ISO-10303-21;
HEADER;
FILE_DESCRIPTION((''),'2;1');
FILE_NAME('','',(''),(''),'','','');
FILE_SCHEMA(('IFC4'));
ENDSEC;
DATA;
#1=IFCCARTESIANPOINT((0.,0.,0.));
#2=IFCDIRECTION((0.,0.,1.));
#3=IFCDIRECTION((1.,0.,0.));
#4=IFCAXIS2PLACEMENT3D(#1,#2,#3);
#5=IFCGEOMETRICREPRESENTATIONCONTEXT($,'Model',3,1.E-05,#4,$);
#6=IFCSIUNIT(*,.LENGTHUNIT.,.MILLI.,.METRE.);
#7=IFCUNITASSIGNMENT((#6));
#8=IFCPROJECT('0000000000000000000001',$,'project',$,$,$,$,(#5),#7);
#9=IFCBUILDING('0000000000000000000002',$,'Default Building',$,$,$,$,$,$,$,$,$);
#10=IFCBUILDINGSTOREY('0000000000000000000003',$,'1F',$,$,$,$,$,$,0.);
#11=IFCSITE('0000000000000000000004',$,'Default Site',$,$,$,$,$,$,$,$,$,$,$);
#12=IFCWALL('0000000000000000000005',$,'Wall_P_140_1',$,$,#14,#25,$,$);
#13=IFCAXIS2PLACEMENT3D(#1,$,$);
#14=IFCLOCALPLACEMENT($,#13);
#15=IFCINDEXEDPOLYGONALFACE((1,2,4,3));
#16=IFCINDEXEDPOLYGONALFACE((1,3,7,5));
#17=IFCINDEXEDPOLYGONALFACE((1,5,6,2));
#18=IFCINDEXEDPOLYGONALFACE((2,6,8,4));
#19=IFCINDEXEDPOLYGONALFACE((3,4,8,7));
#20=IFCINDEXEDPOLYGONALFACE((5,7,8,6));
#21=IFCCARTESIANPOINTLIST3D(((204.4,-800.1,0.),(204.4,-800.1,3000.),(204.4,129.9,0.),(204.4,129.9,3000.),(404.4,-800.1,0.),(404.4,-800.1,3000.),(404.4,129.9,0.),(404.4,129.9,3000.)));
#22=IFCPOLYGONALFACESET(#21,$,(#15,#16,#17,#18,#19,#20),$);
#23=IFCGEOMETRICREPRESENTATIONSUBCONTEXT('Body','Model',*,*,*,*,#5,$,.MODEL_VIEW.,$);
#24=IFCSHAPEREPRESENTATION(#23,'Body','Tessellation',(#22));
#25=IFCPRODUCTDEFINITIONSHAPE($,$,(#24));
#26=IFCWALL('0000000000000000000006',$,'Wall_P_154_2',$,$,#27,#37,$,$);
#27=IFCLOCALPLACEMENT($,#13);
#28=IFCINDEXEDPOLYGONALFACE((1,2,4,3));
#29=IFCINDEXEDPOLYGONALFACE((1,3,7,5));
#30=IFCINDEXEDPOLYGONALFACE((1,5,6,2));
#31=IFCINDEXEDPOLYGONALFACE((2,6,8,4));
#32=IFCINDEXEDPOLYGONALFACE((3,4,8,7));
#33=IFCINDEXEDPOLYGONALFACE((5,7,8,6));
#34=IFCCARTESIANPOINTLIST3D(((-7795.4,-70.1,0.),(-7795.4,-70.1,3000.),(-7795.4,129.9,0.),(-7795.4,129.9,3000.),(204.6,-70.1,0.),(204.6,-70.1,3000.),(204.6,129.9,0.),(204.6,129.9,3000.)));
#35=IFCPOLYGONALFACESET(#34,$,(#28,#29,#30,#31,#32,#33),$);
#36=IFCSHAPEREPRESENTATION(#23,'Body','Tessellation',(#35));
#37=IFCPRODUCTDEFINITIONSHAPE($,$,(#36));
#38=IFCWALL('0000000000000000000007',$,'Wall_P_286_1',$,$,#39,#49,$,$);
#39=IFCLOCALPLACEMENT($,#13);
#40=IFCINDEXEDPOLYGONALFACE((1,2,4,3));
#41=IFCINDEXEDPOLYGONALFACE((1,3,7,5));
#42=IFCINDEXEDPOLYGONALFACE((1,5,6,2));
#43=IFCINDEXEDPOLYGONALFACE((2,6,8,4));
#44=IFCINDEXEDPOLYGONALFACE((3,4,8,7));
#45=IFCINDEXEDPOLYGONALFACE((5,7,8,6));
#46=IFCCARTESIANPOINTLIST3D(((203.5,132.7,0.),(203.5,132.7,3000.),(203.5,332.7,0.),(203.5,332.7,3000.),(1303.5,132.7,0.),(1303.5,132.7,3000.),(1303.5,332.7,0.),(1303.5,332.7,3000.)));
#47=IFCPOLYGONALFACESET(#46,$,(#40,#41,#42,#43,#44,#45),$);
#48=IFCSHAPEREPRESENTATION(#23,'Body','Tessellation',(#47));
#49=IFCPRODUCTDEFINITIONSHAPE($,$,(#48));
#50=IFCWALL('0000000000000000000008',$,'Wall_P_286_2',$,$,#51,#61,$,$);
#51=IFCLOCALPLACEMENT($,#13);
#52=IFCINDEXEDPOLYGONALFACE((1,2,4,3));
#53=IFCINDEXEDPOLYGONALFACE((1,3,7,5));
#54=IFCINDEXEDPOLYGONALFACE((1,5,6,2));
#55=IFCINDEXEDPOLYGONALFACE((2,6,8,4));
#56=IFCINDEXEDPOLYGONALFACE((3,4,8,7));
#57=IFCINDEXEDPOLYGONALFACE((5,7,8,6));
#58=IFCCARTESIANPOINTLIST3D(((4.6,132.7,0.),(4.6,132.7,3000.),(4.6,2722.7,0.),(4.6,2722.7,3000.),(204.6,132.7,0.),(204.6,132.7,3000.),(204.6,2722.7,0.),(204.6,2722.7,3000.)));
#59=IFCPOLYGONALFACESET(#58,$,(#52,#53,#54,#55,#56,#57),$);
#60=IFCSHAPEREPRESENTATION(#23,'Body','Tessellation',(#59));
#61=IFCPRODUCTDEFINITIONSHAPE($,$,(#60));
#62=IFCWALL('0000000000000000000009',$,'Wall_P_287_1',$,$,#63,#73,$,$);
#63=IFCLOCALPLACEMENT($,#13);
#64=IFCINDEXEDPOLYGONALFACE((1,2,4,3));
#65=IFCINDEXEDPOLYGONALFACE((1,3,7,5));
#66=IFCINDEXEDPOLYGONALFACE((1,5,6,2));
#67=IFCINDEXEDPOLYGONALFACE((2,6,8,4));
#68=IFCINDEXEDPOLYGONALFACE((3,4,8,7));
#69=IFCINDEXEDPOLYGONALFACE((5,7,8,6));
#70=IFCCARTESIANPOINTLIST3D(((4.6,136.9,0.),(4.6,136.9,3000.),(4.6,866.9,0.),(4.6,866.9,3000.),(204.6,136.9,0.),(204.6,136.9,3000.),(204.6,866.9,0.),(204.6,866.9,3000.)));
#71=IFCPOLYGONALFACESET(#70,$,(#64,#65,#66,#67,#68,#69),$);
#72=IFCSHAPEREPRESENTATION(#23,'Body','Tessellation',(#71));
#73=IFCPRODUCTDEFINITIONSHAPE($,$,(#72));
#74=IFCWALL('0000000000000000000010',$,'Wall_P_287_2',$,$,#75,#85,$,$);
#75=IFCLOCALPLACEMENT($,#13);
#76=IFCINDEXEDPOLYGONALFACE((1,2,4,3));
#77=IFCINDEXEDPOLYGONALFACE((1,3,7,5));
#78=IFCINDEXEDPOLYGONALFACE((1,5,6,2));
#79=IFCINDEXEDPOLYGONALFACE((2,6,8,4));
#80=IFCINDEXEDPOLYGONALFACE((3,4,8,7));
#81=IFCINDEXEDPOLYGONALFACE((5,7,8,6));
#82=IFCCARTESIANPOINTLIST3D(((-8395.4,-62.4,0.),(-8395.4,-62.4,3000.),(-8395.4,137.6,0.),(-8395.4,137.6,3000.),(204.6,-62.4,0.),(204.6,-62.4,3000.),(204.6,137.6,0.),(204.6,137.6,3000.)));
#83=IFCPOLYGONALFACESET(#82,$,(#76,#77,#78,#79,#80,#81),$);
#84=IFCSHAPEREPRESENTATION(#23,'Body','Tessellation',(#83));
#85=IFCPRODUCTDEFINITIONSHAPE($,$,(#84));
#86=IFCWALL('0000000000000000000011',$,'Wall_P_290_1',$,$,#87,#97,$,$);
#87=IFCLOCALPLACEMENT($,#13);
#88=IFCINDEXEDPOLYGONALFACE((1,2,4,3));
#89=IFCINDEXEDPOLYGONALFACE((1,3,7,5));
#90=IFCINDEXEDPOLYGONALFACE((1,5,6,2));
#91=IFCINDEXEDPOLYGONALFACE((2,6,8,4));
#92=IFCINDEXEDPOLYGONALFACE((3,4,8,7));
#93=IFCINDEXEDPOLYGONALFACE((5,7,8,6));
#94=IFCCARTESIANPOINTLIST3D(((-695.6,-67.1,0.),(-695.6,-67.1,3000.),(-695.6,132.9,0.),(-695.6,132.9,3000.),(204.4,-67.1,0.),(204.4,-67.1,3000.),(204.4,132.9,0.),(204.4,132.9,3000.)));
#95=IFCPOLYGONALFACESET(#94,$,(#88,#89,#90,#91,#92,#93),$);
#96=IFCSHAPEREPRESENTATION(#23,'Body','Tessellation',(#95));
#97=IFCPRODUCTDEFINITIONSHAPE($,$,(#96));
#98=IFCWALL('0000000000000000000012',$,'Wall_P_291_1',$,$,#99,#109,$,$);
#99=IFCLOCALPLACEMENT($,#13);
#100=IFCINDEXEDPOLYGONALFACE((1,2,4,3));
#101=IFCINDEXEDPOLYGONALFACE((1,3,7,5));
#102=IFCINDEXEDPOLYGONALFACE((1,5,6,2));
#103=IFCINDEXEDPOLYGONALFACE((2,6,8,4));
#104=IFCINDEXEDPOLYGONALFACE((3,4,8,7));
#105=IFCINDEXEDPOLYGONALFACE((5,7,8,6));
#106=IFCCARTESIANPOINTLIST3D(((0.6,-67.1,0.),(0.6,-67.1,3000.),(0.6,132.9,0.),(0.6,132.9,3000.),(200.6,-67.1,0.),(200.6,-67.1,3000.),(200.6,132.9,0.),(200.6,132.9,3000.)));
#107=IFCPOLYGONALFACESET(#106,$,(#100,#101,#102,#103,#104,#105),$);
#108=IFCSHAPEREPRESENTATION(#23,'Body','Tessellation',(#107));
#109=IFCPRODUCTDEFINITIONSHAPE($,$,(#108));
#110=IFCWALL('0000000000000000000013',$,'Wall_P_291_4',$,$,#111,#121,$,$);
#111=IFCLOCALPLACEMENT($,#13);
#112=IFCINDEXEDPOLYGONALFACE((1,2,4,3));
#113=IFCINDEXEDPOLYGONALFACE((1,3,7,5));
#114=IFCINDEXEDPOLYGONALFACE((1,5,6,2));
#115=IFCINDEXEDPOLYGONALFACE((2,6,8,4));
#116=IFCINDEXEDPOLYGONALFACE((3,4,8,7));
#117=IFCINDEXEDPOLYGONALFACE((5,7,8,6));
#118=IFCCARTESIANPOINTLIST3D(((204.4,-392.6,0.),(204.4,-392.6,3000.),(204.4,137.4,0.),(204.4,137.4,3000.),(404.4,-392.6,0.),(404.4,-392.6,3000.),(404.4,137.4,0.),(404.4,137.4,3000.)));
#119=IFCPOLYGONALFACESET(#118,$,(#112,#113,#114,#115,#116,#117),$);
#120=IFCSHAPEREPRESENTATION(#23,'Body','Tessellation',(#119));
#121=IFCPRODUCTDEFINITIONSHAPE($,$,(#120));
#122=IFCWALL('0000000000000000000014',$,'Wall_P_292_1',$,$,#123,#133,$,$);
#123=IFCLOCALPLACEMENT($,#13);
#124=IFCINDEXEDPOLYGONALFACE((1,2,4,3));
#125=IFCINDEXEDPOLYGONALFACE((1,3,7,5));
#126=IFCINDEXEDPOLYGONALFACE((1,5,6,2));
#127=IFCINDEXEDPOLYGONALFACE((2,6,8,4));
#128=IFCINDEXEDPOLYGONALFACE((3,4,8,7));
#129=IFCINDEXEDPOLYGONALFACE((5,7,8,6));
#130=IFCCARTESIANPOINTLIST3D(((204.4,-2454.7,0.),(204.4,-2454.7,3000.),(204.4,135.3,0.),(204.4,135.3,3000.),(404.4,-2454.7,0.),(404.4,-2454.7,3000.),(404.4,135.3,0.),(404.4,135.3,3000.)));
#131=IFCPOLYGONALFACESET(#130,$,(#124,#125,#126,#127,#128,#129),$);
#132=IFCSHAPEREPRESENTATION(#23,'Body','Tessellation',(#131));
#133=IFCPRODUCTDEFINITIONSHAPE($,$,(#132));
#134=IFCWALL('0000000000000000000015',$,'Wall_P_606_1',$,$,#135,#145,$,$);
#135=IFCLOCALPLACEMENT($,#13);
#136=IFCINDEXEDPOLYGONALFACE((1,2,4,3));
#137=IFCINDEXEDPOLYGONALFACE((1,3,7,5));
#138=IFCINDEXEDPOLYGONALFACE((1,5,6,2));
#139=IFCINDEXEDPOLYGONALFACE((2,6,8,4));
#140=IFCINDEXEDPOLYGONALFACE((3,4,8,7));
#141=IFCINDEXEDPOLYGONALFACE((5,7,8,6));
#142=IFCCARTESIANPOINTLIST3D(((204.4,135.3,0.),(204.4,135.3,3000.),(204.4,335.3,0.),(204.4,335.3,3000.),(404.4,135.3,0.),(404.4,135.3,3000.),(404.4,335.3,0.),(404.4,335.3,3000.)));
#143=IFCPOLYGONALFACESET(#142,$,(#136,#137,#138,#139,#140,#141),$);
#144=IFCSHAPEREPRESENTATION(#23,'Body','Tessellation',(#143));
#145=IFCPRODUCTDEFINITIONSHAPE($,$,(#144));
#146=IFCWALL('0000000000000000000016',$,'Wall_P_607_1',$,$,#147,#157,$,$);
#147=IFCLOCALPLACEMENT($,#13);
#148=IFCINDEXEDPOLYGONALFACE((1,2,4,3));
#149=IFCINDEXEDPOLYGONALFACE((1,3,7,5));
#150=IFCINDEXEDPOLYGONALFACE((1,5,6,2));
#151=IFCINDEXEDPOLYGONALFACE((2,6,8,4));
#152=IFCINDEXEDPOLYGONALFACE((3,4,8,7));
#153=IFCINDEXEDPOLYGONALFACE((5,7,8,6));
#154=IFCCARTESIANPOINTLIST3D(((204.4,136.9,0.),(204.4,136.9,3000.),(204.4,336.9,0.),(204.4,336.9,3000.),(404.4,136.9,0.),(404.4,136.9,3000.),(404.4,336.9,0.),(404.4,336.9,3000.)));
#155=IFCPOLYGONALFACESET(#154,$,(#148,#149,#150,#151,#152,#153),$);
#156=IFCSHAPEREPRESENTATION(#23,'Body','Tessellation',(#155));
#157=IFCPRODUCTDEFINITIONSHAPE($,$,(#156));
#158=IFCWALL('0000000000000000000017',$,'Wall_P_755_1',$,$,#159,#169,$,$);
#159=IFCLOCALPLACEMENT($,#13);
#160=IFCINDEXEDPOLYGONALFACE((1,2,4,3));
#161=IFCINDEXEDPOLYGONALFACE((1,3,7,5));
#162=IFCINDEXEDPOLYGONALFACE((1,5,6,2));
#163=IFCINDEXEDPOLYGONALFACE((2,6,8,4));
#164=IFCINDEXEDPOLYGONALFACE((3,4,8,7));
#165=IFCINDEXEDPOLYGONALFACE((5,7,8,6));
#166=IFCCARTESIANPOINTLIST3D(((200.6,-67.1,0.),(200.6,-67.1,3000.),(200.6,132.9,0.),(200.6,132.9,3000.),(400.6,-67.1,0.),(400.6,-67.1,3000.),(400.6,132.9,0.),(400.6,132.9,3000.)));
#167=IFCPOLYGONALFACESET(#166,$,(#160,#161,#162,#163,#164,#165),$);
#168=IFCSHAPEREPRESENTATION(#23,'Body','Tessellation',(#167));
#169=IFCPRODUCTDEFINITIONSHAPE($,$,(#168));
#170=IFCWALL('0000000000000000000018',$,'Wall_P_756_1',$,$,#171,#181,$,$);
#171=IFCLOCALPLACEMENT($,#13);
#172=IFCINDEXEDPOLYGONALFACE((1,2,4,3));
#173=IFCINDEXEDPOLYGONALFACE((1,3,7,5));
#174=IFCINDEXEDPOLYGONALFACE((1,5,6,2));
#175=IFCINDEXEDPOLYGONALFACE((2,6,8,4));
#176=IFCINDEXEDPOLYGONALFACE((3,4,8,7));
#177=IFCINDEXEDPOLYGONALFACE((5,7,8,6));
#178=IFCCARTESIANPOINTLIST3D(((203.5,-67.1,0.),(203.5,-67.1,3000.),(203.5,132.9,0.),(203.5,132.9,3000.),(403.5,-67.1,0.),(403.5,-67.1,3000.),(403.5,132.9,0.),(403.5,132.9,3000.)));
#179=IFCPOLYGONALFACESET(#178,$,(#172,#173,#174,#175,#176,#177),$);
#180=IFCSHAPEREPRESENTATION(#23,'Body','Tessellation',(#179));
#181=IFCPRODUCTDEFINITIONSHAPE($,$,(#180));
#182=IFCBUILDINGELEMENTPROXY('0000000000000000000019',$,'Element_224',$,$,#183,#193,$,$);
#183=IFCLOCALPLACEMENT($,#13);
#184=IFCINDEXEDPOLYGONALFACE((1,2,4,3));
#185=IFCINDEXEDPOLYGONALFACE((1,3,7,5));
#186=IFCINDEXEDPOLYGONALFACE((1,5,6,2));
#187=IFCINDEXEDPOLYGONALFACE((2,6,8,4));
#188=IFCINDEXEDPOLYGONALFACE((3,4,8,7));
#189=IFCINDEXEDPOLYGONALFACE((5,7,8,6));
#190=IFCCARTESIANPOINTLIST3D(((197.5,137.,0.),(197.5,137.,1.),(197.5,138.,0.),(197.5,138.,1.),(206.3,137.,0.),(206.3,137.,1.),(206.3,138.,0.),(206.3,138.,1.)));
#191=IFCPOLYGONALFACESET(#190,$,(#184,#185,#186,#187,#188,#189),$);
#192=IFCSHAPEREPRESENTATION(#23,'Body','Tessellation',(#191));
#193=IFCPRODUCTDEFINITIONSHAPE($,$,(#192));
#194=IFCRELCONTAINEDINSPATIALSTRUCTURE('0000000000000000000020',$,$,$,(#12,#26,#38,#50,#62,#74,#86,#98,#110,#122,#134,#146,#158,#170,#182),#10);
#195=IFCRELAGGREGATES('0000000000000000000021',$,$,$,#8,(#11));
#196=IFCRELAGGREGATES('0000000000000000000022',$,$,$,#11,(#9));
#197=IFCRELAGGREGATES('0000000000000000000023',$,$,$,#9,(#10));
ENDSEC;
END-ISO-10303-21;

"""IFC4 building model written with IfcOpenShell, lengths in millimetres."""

from ifc_helpers import new_model, si_unit, frame, origin, origin_with_axes, place, context, subcontext, project, spatial, indexed_curve, rectangle, outline, extrude, element, save


model = new_model("IFC4")

# Units and contexts
model_context = context("Model", 3, precision=1e-05, world=origin_with_axes())
body_context = subcontext(model_context, "Body", "Model", "MODEL_VIEW")
ifc_project = project(units=[si_unit("LENGTHUNIT", "METRE", prefix="MILLI")], contexts=[model_context])

# Site, building, storey
site = spatial("IfcSite", under=ifc_project, Name="Default Site")
building = spatial("IfcBuilding", under=site, Name="Default Building")
storey = spatial("IfcBuildingStorey", under=building, Name="1F", Elevation=0.0)

# Walls
wall_1_placement = place(None, frame((204.4, 129.9, 0.0), z_axis=(0.0, 0.0, 1.0), x_axis=(0.0, -1.0, 0.0)))
element("IfcWall", 1, at=wall_1_placement, inside=storey, Name="Wall_P_140_1", context=body_context, shape_type="SweptSolid", body=[
    extrude(outline(indexed_curve([(0.0, 0.0), (0.0, 200.0), (930.0, 200.0), (930.0, 0.0), (0.0, 0.0)], self_intersect=False)), origin_with_axes(), (0.0, 0.0, 1.0), 3000.0),
])
wall_2_placement = place(None, frame((204.6, 129.9, 0.0), z_axis=(0.0, 0.0, 1.0), x_axis=(-1.0, 0.0, 0.0)))
element("IfcWall", 2, at=wall_2_placement, inside=storey, Name="Wall_P_154_2", context=body_context, shape_type="SweptSolid", body=[
    extrude(outline(indexed_curve([(0.0, 0.0), (0.0, 200.0), (8000.0, 200.0), (8000.0, 0.0), (0.0, 0.0)], self_intersect=False)), origin_with_axes(), (0.0, 0.0, 1.0), 3000.0),
])
wall_3_placement = place(None, frame((203.5, 132.7, 0.0), z_axis=(0.0, 0.0, 1.0), x_axis=(1.0, 0.0, 0.0)))
element("IfcWall", 3, at=wall_3_placement, inside=storey, Name="Wall_P_286_1", context=body_context, shape_type="SweptSolid", body=[
    extrude(outline(indexed_curve([(0.0, 0.0), (0.0, 200.0), (1100.0, 200.0), (1100.0, 0.0), (0.0, 0.0)], self_intersect=False)), origin_with_axes(), (0.0, 0.0, 1.0), 3000.0),
])
wall_4_placement = place(None, frame((204.6, 132.7, 0.0), z_axis=(0.0, 0.0, 1.0), x_axis=(0.0, 1.0, 0.0)))
element("IfcWall", 4, at=wall_4_placement, inside=storey, Name="Wall_P_286_2", context=body_context, shape_type="SweptSolid", body=[
    extrude(outline(indexed_curve([(0.0, 0.0), (0.0, 200.0), (2590.0, 200.0), (2590.0, 0.0), (0.0, 0.0)], self_intersect=False)), origin_with_axes(), (0.0, 0.0, 1.0), 3000.0),
])
wall_5_placement = place(None, frame((204.6, 136.9, 0.0), z_axis=(0.0, 0.0, 1.0), x_axis=(0.0, 1.0, 0.0)))
element("IfcWall", 5, at=wall_5_placement, inside=storey, Name="Wall_P_287_1", context=body_context, shape_type="SweptSolid", body=[
    extrude(outline(indexed_curve([(0.0, 0.0), (0.0, 200.0), (730.0, 200.0), (730.0, 0.0), (0.0, 0.0)], self_intersect=False)), origin_with_axes(), (0.0, 0.0, 1.0), 3000.0),
])
wall_6_placement = place(None, frame((204.6, 137.6, 0.0), z_axis=(0.0, 0.0, 1.0), x_axis=(-1.0, 0.0, 0.0)))
element("IfcWall", 6, at=wall_6_placement, inside=storey, Name="Wall_P_287_2", context=body_context, shape_type="SweptSolid", body=[
    extrude(outline(indexed_curve([(0.0, 0.0), (0.0, 200.0), (8600.0, 200.0), (8600.0, 0.0), (0.0, 0.0)], self_intersect=False)), origin_with_axes(), (0.0, 0.0, 1.0), 3000.0),
])
wall_7_placement = place(None, frame((204.4, 132.9, 0.0), z_axis=(0.0, 0.0, 1.0), x_axis=(-1.0, 0.0, 0.0)))
element("IfcWall", 7, at=wall_7_placement, inside=storey, Name="Wall_P_290_1", context=body_context, shape_type="SweptSolid", body=[
    extrude(outline(indexed_curve([(0.0, 0.0), (0.0, 200.0), (900.0, 200.0), (900.0, 0.0), (0.0, 0.0)], self_intersect=False)), origin_with_axes(), (0.0, 0.0, 1.0), 3000.0),
])
wall_8_placement = place(None, frame((200.6, 132.9, 0.0), z_axis=(0.0, 0.0, 1.0), x_axis=(-1.0, 0.0, 0.0)))
element("IfcWall", 8, at=wall_8_placement, inside=storey, Name="Wall_P_291_1", context=body_context, shape_type="SweptSolid", body=[
    extrude(outline(indexed_curve([(0.0, 0.0), (0.0, 200.0), (200.0, 200.0), (200.0, 0.0), (0.0, 0.0)], self_intersect=False)), origin_with_axes(), (0.0, 0.0, 1.0), 3000.0),
])
wall_9_placement = place(None, frame((204.4, 137.4, 0.0), z_axis=(0.0, 0.0, 1.0), x_axis=(0.0, -1.0, 0.0)))
element("IfcWall", 9, at=wall_9_placement, inside=storey, Name="Wall_P_291_4", context=body_context, shape_type="SweptSolid", body=[
    extrude(outline(indexed_curve([(0.0, 0.0), (0.0, 200.0), (530.0, 200.0), (530.0, 0.0), (0.0, 0.0)], self_intersect=False)), origin_with_axes(), (0.0, 0.0, 1.0), 3000.0),
])
wall_10_placement = place(None, frame((204.4, 135.3, 0.0), z_axis=(0.0, 0.0, 1.0), x_axis=(0.0, -1.0, 0.0)))
element("IfcWall", 10, at=wall_10_placement, inside=storey, Name="Wall_P_292_1", context=body_context, shape_type="SweptSolid", body=[
    extrude(outline(indexed_curve([(0.0, 0.0), (0.0, 200.0), (2590.0, 200.0), (2590.0, 0.0), (0.0, 0.0)], self_intersect=False)), origin_with_axes(), (0.0, 0.0, 1.0), 3000.0),
])
for number, where, z_axis, x_axis, name in (
    (11, (204.4, 135.3, 0.0), (0.0, 0.0, 1.0), (1.0, 0.0, 0.0), "Wall_P_606_1"),
    (12, (204.4, 136.9, 0.0), (0.0, 0.0, 1.0), (1.0, 0.0, 0.0), "Wall_P_607_1"),
    (13, (200.6, 132.9, 0.0), (0.0, 0.0, 1.0), (0.0, -1.0, 0.0), "Wall_P_755_1"),
    (14, (203.5, 132.9, 0.0), (0.0, 0.0, 1.0), (0.0, -1.0, 0.0), "Wall_P_756_1"),
):
    element("IfcWall", number, at=place(None, frame(where, z_axis=z_axis, x_axis=x_axis)), inside=storey, Name=name, context=body_context, shape_type="SweptSolid", body=[
        extrude(outline(indexed_curve([(0.0, 0.0), (0.0, 200.0), (200.0, 200.0), (200.0, 0.0), (0.0, 0.0)], self_intersect=False)), origin_with_axes(), (0.0, 0.0, 1.0), 3000.0),
    ])

# Building element proxy
proxy_1_placement = place(None, frame((201.9, 137.5, 0.0), z_axis=(0.0, 0.0, 1.0), x_axis=(1.0, 0.0, 0.0)))
element("IfcBuildingElementProxy", 15, at=proxy_1_placement, inside=storey, Name="Element_224", context=body_context, shape_type="SweptSolid", body=[
    extrude(rectangle(XDim=8.8, YDim=1.0), origin(), (0.0, 0.0, 1.0), 1.0),
])

save(model, "model.ifc")
